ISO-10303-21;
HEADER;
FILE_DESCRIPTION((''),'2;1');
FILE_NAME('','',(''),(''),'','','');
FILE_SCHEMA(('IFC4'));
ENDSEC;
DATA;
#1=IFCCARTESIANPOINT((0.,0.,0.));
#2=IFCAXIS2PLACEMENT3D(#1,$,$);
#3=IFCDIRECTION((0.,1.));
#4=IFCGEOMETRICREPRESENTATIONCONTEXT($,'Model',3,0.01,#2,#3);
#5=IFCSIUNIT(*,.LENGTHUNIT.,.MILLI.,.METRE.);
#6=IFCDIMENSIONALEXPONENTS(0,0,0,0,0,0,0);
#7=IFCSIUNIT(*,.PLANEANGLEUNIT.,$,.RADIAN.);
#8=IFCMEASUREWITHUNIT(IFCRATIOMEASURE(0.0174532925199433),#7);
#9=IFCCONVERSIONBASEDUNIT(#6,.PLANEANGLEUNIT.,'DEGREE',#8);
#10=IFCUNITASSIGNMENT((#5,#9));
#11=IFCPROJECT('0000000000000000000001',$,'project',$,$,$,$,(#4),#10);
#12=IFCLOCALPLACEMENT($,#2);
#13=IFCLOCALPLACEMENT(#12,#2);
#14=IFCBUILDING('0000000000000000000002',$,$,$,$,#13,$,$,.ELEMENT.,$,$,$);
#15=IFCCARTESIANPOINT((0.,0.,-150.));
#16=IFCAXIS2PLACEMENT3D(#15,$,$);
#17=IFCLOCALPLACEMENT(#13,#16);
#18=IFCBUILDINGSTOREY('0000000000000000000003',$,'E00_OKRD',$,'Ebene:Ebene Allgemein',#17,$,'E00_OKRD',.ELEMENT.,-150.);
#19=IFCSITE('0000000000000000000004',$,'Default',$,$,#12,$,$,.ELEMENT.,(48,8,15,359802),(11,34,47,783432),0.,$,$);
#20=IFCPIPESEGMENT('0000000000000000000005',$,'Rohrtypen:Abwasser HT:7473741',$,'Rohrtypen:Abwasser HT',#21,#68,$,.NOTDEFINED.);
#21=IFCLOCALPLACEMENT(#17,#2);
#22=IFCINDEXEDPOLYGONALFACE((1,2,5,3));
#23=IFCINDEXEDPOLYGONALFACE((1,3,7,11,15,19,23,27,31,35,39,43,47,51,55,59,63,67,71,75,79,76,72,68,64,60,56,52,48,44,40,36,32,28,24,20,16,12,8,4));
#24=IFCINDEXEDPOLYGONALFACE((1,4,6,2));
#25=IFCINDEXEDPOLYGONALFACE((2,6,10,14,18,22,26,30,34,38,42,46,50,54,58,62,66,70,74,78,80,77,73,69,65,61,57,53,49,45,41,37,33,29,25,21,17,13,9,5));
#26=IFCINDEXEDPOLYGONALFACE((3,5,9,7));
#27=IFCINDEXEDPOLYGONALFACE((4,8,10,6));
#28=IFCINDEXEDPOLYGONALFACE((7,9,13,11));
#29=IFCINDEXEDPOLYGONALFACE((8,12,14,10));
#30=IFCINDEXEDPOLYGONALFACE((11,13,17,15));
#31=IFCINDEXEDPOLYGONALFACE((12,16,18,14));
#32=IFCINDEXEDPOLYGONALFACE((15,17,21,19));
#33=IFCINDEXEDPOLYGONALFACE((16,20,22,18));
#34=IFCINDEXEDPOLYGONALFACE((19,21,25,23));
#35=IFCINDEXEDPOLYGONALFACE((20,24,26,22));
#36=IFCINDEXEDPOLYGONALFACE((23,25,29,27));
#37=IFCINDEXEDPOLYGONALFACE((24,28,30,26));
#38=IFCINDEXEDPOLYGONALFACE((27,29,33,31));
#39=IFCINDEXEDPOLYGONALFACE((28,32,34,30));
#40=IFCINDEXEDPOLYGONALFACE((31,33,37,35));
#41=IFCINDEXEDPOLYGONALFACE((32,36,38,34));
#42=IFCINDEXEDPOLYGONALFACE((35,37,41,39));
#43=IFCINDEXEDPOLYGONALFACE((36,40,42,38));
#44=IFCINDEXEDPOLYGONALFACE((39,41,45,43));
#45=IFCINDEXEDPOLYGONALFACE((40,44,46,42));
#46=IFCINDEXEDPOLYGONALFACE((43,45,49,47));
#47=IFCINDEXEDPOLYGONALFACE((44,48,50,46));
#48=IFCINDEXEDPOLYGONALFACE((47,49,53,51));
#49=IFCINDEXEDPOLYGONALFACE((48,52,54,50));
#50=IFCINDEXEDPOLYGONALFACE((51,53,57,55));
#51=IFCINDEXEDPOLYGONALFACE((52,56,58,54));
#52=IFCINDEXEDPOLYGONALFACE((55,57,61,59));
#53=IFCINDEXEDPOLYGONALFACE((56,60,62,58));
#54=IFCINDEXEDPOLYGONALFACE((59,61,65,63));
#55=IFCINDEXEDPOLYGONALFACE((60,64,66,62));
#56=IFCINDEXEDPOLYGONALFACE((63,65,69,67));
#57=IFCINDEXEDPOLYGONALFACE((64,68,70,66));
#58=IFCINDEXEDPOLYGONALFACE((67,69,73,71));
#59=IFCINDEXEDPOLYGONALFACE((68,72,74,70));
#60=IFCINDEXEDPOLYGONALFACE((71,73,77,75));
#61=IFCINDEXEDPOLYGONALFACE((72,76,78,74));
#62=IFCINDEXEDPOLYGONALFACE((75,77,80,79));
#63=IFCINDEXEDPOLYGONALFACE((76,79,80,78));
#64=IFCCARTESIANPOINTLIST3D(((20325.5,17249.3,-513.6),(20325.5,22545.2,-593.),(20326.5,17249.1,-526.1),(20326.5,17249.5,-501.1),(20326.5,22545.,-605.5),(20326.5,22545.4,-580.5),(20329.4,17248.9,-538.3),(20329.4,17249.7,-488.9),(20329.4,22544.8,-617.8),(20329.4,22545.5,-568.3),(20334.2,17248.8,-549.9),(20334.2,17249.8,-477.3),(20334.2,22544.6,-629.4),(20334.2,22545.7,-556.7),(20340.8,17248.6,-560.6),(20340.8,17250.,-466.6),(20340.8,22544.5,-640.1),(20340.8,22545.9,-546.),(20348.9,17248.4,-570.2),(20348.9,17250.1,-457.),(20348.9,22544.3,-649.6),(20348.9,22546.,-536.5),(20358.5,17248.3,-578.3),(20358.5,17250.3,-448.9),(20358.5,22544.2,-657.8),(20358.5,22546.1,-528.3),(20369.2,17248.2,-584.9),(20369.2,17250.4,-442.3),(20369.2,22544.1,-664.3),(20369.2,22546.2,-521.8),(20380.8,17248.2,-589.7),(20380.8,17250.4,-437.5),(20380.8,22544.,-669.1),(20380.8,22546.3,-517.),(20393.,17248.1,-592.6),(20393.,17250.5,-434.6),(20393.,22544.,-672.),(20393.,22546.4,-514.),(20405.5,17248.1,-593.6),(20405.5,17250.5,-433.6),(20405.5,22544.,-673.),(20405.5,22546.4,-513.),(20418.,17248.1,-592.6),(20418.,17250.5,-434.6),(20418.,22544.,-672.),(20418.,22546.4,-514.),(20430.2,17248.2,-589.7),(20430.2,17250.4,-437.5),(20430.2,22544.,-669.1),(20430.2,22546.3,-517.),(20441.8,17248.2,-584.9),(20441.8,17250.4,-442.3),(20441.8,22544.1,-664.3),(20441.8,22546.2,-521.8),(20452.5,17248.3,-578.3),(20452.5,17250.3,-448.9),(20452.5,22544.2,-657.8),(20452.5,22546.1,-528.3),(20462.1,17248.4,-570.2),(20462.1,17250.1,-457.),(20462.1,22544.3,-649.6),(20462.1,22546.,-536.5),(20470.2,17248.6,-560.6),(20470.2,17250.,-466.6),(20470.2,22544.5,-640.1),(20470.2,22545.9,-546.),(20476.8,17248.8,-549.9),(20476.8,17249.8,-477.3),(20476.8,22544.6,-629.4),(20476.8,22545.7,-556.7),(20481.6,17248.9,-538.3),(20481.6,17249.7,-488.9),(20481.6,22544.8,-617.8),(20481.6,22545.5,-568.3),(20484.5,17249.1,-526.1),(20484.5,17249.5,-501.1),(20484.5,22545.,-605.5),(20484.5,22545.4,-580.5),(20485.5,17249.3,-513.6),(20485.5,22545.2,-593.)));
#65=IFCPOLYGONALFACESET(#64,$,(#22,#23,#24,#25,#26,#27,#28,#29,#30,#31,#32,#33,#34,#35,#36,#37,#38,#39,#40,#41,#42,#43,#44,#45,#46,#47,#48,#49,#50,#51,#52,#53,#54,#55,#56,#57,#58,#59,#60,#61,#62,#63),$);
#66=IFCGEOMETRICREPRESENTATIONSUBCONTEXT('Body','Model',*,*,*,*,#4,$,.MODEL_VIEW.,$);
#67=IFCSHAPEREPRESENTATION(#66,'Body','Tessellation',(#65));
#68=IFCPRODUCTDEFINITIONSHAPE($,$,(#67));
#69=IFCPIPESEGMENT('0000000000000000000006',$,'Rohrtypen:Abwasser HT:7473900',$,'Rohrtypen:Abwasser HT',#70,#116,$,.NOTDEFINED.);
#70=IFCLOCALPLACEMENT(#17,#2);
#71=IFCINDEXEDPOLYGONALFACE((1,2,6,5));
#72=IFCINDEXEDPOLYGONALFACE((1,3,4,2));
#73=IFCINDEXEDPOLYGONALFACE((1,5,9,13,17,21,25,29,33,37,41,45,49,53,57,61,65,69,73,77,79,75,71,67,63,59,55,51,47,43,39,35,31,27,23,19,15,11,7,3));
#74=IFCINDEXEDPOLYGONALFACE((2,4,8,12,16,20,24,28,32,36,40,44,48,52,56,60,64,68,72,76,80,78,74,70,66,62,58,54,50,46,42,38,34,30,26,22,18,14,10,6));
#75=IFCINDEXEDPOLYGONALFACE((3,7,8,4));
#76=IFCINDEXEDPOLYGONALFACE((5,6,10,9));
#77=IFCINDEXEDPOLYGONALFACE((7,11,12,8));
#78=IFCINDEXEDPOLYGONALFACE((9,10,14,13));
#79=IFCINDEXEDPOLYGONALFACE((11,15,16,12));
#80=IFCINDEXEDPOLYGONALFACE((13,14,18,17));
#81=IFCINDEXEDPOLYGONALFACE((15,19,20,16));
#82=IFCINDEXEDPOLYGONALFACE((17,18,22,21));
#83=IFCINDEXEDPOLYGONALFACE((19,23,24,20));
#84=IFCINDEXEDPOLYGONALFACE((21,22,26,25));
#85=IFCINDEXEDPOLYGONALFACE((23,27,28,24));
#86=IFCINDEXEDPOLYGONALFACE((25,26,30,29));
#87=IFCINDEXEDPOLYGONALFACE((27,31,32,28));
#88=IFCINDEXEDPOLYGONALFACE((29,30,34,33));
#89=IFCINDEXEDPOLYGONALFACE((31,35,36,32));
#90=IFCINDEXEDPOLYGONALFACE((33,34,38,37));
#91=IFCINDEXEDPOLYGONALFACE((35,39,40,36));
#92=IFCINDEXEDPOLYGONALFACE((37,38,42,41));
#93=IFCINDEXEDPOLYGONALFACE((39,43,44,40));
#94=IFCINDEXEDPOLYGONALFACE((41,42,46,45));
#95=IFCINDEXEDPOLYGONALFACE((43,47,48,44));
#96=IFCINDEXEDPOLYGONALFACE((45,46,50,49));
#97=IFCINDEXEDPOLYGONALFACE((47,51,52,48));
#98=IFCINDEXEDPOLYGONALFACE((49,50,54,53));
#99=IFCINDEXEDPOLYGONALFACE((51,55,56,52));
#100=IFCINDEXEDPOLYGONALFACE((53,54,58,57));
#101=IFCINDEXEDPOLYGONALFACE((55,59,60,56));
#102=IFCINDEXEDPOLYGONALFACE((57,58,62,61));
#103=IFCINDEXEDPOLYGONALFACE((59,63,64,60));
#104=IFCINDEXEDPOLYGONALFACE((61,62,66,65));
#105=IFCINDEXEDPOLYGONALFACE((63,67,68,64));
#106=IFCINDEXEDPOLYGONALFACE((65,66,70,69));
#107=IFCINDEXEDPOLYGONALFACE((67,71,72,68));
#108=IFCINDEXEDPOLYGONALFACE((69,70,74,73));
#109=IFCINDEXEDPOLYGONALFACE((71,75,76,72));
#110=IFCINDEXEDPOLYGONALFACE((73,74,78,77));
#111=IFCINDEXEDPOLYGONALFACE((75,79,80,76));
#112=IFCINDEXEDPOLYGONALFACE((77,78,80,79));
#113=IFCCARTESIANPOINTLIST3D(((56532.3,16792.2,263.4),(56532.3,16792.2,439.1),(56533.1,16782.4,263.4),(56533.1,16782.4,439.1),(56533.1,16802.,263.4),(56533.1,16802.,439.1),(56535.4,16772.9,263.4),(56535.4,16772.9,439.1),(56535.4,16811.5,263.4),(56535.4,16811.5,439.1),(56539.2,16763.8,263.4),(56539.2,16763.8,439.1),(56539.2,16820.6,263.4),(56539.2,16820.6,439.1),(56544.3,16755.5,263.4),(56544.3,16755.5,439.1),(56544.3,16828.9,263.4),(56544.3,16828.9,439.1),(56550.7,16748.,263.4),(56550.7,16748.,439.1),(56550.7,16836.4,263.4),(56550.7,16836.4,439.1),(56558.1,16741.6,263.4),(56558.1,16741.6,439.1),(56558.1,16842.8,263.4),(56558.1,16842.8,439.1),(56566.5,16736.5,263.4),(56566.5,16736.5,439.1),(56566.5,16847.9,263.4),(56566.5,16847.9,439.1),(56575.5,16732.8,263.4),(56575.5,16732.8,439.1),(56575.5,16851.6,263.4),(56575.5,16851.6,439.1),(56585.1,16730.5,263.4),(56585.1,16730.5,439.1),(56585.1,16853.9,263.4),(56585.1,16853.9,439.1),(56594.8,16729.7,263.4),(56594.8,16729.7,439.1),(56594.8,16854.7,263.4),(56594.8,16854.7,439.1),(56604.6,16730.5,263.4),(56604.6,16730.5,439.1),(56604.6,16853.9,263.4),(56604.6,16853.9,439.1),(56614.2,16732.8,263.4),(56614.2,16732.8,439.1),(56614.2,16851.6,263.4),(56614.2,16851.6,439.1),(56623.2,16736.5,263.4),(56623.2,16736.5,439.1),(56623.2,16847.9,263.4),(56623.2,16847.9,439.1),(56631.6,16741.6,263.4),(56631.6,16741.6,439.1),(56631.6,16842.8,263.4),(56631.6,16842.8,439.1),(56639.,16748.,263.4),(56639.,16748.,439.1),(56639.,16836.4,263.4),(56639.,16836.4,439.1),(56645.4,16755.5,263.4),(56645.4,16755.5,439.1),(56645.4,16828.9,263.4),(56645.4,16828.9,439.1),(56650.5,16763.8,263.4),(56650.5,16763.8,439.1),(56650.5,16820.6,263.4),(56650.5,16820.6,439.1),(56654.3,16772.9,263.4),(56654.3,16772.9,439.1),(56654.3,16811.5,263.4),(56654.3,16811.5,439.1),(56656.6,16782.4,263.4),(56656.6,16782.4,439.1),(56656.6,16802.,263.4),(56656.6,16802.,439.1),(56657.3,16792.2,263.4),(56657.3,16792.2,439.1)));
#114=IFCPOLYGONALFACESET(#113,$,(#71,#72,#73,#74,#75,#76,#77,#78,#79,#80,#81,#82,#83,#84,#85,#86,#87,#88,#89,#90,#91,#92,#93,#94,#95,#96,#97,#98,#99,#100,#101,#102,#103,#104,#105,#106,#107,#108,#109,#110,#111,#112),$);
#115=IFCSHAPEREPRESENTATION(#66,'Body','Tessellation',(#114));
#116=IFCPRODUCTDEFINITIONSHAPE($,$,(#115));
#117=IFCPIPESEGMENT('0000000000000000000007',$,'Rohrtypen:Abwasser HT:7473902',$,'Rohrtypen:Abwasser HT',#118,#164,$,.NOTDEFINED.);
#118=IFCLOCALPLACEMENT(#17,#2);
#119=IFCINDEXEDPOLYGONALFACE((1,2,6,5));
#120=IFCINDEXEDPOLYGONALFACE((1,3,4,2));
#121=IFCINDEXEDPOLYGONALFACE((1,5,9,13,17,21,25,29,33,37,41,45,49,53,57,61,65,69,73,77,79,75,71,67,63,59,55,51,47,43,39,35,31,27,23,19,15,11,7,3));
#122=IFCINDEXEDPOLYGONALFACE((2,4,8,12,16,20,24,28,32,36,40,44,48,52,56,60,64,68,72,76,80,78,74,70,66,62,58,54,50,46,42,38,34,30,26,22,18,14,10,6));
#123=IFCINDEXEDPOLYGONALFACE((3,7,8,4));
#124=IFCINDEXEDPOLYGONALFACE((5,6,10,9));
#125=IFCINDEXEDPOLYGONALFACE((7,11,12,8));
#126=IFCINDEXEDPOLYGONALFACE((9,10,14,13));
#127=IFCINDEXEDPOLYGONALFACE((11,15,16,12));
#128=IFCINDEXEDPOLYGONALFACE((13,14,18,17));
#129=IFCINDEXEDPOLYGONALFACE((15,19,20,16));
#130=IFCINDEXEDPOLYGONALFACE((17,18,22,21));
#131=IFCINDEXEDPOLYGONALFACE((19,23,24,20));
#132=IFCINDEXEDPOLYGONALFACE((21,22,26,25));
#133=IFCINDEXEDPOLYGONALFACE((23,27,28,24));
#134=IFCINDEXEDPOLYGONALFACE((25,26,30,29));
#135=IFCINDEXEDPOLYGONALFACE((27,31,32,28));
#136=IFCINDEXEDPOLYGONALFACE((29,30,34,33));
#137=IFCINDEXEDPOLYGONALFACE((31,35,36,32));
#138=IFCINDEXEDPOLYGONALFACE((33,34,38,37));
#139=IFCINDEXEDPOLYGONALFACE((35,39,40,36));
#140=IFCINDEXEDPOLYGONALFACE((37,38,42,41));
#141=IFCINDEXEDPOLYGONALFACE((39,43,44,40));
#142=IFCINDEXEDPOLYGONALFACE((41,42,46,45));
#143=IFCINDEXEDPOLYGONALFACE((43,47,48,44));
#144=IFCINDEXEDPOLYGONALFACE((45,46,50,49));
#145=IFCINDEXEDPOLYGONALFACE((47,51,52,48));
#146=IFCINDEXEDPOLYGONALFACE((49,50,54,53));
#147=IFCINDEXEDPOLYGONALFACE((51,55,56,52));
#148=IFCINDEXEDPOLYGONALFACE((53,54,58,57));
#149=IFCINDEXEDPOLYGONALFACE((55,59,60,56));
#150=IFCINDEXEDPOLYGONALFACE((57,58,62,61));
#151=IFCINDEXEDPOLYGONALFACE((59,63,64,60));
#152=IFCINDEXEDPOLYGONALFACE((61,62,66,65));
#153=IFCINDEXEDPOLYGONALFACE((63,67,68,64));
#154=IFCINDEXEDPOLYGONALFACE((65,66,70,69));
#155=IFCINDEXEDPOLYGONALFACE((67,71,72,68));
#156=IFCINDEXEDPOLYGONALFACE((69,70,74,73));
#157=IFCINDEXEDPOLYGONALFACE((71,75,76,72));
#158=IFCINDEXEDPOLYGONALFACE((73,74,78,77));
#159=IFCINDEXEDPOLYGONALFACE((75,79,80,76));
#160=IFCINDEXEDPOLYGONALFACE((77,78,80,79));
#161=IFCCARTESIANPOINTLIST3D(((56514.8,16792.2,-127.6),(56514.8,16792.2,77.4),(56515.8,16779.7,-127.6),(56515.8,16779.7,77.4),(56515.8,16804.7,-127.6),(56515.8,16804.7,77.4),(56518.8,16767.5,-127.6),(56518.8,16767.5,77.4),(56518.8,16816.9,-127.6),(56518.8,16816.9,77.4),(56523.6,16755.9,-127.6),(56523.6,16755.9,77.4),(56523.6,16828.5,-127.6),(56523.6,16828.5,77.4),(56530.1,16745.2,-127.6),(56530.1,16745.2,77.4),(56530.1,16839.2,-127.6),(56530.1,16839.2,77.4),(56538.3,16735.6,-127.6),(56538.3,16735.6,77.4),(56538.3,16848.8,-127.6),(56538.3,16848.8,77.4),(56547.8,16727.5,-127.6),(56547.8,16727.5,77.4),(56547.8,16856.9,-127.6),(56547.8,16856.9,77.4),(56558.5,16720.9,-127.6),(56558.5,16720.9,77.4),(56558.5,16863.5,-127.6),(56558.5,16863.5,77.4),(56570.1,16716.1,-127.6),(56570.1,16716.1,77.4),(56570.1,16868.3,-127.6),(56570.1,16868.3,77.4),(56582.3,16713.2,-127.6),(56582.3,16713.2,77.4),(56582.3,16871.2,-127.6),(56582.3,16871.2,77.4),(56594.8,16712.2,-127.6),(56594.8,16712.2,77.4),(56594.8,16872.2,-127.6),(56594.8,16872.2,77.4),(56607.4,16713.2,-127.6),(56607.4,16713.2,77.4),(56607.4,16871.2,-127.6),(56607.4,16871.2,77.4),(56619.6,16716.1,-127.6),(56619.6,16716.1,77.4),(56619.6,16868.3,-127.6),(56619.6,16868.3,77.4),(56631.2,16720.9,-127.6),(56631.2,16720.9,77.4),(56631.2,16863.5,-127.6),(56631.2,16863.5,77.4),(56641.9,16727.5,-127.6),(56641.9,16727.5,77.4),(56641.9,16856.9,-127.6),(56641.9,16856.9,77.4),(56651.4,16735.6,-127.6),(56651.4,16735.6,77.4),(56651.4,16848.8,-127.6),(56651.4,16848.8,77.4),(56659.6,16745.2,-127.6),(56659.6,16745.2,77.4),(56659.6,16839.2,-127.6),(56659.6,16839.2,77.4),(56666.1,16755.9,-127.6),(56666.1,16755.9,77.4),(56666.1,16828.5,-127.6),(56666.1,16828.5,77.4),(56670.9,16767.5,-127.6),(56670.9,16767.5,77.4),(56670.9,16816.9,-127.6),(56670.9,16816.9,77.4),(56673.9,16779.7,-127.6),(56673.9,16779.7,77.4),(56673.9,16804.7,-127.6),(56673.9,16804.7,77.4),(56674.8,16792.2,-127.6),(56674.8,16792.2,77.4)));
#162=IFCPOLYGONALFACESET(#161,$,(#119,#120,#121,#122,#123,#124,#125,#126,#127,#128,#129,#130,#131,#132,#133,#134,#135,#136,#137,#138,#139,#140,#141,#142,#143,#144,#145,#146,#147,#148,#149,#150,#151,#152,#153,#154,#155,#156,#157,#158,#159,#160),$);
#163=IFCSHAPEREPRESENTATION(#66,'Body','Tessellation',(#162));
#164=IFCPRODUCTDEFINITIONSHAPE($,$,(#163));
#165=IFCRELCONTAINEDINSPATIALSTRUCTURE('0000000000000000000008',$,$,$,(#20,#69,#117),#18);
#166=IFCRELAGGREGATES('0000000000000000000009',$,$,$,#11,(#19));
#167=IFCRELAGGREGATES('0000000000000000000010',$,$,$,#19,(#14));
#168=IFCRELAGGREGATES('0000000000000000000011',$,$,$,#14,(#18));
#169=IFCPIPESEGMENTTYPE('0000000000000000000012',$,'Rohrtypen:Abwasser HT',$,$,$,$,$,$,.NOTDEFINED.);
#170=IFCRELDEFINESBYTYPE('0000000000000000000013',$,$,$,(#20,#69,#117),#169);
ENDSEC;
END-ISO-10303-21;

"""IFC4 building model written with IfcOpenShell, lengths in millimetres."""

from ifc_helpers import new_model, entity, si_unit, converted_unit, direction, frame, origin, place, context, subcontext, project, spatial, indexed_curve, outline, extrude, type_object, element, save


model = new_model("IFC4")

# Units and contexts
model_context = context("Model", 3, precision=0.01, world=origin(), true_north=direction((0.0, 1.0)))
body_context = subcontext(model_context, "Body", "Model", "MODEL_VIEW")
ifc_project = project(units=[si_unit("LENGTHUNIT", "METRE", prefix="MILLI"), converted_unit("PLANEANGLEUNIT", "DEGREE", entity("IfcRatioMeasure", 0.0174532925199433), si_unit("PLANEANGLEUNIT", "RADIAN"), dimensions=[0, 0, 0, 0, 0, 0, 0])], contexts=[model_context])

# Site, building, storey
site_placement = place(None, origin())
site = spatial("IfcSite", under=ifc_project, at=site_placement, Name="Default", CompositionType="ELEMENT", RefLatitude=(48, 8, 15, 359802), RefLongitude=(11, 34, 47, 783432), RefElevation=0.0)
building_placement = place(site_placement, origin())
building = spatial("IfcBuilding", under=site, at=building_placement, CompositionType="ELEMENT")
storey_placement = place(building_placement, frame((0.0, 0.0, -150.0)))
storey = spatial("IfcBuildingStorey", under=building, at=storey_placement, Name="E00_OKRD", ObjectType="Ebene:Ebene Allgemein", LongName="E00_OKRD", CompositionType="ELEMENT", Elevation=-150.0)

# Pipe segments
pipe_segment_type_1 = type_object("IfcPipeSegmentType", Name="Rohrtypen:Abwasser HT", PredefinedType="NOTDEFINED")
pipe_segment_1_placement = place(storey_placement, origin())
element("IfcPipeSegment", 1, at=pipe_segment_1_placement, inside=storey, type_object=pipe_segment_type_1, Name="Rohrtypen:Abwasser HT:7473741", ObjectType="Rohrtypen:Abwasser HT", PredefinedType="NOTDEFINED", context=body_context, shape_type="SweptSolid", body=[
    extrude(outline(indexed_curve([(80.0, 0.0), (79.0, 12.5), (76.1, 24.7), (71.3, 36.3), (64.7, 47.0), (56.6, 56.6), (47.0, 64.7), (36.3, 71.3), (24.7, 76.1), (12.5, 79.0), (0.0, 80.0), (-12.5, 79.0), (-24.7, 76.1), (-36.3, 71.3), (-47.0, 64.7), (-56.6, 56.6), (-64.7, 47.0), (-71.3, 36.3), (-76.1, 24.7), (-79.0, 12.5), (-80.0, 0.0), (-79.0, -12.5), (-76.1, -24.7), (-71.3, -36.3), (-64.7, -47.0), (-56.6, -56.6), (-47.0, -64.7), (-36.3, -71.3), (-24.7, -76.1), (-12.5, -79.0), (0.0, -80.0), (12.5, -79.0), (24.7, -76.1), (36.3, -71.3), (47.0, -64.7), (56.6, -56.6), (64.7, -47.0), (71.3, -36.3), (76.1, -24.7), (79.0, -12.5), (80.0, 0.0)], self_intersect=False)), frame((20405.5, 22545.2, -593.0), z_axis=(0.0, -0.999888, 0.014998), x_axis=(1.0, 0.0, 0.0)), (0.0, 0.0, 1.0), 5296.5),
])
pipe_segment_2_placement = place(storey_placement, origin())
element("IfcPipeSegment", 2, at=pipe_segment_2_placement, inside=storey, type_object=pipe_segment_type_1, Name="Rohrtypen:Abwasser HT:7473900", ObjectType="Rohrtypen:Abwasser HT", PredefinedType="NOTDEFINED", context=body_context, shape_type="SweptSolid", body=[
    extrude(outline(indexed_curve([(62.5, 0.0), (61.7, 9.8), (59.4, 19.3), (55.7, 28.4), (50.6, 36.7), (44.2, 44.2), (36.7, 50.6), (28.4, 55.7), (19.3, 59.4), (9.8, 61.7), (0.0, 62.5), (-9.8, 61.7), (-19.3, 59.4), (-28.4, 55.7), (-36.7, 50.6), (-44.2, 44.2), (-50.6, 36.7), (-55.7, 28.4), (-59.4, 19.3), (-61.7, 9.8), (-62.5, 0.0), (-61.7, -9.8), (-59.4, -19.3), (-55.7, -28.4), (-50.6, -36.7), (-44.2, -44.2), (-36.7, -50.6), (-28.4, -55.7), (-19.3, -59.4), (-9.8, -61.7), (0.0, -62.5), (9.8, -61.7), (19.3, -59.4), (28.4, -55.7), (36.7, -50.6), (44.2, -44.2), (50.6, -36.7), (55.7, -28.4), (59.4, -19.3), (61.7, -9.8), (62.5, 0.0)], self_intersect=False)), frame((56594.8, 16792.2, 263.4)), (0.0, 0.0, 1.0), 175.7),
])
pipe_segment_3_placement = place(storey_placement, origin())
element("IfcPipeSegment", 3, at=pipe_segment_3_placement, inside=storey, type_object=pipe_segment_type_1, Name="Rohrtypen:Abwasser HT:7473902", ObjectType="Rohrtypen:Abwasser HT", PredefinedType="NOTDEFINED", context=body_context, shape_type="SweptSolid", body=[
    extrude(outline(indexed_curve([(80.0, 0.0), (79.0, 12.5), (76.1, 24.7), (71.3, 36.3), (64.7, 47.0), (56.6, 56.6), (47.0, 64.7), (36.3, 71.3), (24.7, 76.1), (12.5, 79.0), (0.0, 80.0), (-12.5, 79.0), (-24.7, 76.1), (-36.3, 71.3), (-47.0, 64.7), (-56.6, 56.6), (-64.7, 47.0), (-71.3, 36.3), (-76.1, 24.7), (-79.0, 12.5), (-80.0, 0.0), (-79.0, -12.5), (-76.1, -24.7), (-71.3, -36.3), (-64.7, -47.0), (-56.6, -56.6), (-47.0, -64.7), (-36.3, -71.3), (-24.7, -76.1), (-12.5, -79.0), (0.0, -80.0), (12.5, -79.0), (24.7, -76.1), (36.3, -71.3), (47.0, -64.7), (56.6, -56.6), (64.7, -47.0), (71.3, -36.3), (76.1, -24.7), (79.0, -12.5), (80.0, 0.0)], self_intersect=False)), frame((56594.8, 16792.2, -127.6)), (0.0, 0.0, 1.0), 205.0),
])

save(model, "model.ifc")
